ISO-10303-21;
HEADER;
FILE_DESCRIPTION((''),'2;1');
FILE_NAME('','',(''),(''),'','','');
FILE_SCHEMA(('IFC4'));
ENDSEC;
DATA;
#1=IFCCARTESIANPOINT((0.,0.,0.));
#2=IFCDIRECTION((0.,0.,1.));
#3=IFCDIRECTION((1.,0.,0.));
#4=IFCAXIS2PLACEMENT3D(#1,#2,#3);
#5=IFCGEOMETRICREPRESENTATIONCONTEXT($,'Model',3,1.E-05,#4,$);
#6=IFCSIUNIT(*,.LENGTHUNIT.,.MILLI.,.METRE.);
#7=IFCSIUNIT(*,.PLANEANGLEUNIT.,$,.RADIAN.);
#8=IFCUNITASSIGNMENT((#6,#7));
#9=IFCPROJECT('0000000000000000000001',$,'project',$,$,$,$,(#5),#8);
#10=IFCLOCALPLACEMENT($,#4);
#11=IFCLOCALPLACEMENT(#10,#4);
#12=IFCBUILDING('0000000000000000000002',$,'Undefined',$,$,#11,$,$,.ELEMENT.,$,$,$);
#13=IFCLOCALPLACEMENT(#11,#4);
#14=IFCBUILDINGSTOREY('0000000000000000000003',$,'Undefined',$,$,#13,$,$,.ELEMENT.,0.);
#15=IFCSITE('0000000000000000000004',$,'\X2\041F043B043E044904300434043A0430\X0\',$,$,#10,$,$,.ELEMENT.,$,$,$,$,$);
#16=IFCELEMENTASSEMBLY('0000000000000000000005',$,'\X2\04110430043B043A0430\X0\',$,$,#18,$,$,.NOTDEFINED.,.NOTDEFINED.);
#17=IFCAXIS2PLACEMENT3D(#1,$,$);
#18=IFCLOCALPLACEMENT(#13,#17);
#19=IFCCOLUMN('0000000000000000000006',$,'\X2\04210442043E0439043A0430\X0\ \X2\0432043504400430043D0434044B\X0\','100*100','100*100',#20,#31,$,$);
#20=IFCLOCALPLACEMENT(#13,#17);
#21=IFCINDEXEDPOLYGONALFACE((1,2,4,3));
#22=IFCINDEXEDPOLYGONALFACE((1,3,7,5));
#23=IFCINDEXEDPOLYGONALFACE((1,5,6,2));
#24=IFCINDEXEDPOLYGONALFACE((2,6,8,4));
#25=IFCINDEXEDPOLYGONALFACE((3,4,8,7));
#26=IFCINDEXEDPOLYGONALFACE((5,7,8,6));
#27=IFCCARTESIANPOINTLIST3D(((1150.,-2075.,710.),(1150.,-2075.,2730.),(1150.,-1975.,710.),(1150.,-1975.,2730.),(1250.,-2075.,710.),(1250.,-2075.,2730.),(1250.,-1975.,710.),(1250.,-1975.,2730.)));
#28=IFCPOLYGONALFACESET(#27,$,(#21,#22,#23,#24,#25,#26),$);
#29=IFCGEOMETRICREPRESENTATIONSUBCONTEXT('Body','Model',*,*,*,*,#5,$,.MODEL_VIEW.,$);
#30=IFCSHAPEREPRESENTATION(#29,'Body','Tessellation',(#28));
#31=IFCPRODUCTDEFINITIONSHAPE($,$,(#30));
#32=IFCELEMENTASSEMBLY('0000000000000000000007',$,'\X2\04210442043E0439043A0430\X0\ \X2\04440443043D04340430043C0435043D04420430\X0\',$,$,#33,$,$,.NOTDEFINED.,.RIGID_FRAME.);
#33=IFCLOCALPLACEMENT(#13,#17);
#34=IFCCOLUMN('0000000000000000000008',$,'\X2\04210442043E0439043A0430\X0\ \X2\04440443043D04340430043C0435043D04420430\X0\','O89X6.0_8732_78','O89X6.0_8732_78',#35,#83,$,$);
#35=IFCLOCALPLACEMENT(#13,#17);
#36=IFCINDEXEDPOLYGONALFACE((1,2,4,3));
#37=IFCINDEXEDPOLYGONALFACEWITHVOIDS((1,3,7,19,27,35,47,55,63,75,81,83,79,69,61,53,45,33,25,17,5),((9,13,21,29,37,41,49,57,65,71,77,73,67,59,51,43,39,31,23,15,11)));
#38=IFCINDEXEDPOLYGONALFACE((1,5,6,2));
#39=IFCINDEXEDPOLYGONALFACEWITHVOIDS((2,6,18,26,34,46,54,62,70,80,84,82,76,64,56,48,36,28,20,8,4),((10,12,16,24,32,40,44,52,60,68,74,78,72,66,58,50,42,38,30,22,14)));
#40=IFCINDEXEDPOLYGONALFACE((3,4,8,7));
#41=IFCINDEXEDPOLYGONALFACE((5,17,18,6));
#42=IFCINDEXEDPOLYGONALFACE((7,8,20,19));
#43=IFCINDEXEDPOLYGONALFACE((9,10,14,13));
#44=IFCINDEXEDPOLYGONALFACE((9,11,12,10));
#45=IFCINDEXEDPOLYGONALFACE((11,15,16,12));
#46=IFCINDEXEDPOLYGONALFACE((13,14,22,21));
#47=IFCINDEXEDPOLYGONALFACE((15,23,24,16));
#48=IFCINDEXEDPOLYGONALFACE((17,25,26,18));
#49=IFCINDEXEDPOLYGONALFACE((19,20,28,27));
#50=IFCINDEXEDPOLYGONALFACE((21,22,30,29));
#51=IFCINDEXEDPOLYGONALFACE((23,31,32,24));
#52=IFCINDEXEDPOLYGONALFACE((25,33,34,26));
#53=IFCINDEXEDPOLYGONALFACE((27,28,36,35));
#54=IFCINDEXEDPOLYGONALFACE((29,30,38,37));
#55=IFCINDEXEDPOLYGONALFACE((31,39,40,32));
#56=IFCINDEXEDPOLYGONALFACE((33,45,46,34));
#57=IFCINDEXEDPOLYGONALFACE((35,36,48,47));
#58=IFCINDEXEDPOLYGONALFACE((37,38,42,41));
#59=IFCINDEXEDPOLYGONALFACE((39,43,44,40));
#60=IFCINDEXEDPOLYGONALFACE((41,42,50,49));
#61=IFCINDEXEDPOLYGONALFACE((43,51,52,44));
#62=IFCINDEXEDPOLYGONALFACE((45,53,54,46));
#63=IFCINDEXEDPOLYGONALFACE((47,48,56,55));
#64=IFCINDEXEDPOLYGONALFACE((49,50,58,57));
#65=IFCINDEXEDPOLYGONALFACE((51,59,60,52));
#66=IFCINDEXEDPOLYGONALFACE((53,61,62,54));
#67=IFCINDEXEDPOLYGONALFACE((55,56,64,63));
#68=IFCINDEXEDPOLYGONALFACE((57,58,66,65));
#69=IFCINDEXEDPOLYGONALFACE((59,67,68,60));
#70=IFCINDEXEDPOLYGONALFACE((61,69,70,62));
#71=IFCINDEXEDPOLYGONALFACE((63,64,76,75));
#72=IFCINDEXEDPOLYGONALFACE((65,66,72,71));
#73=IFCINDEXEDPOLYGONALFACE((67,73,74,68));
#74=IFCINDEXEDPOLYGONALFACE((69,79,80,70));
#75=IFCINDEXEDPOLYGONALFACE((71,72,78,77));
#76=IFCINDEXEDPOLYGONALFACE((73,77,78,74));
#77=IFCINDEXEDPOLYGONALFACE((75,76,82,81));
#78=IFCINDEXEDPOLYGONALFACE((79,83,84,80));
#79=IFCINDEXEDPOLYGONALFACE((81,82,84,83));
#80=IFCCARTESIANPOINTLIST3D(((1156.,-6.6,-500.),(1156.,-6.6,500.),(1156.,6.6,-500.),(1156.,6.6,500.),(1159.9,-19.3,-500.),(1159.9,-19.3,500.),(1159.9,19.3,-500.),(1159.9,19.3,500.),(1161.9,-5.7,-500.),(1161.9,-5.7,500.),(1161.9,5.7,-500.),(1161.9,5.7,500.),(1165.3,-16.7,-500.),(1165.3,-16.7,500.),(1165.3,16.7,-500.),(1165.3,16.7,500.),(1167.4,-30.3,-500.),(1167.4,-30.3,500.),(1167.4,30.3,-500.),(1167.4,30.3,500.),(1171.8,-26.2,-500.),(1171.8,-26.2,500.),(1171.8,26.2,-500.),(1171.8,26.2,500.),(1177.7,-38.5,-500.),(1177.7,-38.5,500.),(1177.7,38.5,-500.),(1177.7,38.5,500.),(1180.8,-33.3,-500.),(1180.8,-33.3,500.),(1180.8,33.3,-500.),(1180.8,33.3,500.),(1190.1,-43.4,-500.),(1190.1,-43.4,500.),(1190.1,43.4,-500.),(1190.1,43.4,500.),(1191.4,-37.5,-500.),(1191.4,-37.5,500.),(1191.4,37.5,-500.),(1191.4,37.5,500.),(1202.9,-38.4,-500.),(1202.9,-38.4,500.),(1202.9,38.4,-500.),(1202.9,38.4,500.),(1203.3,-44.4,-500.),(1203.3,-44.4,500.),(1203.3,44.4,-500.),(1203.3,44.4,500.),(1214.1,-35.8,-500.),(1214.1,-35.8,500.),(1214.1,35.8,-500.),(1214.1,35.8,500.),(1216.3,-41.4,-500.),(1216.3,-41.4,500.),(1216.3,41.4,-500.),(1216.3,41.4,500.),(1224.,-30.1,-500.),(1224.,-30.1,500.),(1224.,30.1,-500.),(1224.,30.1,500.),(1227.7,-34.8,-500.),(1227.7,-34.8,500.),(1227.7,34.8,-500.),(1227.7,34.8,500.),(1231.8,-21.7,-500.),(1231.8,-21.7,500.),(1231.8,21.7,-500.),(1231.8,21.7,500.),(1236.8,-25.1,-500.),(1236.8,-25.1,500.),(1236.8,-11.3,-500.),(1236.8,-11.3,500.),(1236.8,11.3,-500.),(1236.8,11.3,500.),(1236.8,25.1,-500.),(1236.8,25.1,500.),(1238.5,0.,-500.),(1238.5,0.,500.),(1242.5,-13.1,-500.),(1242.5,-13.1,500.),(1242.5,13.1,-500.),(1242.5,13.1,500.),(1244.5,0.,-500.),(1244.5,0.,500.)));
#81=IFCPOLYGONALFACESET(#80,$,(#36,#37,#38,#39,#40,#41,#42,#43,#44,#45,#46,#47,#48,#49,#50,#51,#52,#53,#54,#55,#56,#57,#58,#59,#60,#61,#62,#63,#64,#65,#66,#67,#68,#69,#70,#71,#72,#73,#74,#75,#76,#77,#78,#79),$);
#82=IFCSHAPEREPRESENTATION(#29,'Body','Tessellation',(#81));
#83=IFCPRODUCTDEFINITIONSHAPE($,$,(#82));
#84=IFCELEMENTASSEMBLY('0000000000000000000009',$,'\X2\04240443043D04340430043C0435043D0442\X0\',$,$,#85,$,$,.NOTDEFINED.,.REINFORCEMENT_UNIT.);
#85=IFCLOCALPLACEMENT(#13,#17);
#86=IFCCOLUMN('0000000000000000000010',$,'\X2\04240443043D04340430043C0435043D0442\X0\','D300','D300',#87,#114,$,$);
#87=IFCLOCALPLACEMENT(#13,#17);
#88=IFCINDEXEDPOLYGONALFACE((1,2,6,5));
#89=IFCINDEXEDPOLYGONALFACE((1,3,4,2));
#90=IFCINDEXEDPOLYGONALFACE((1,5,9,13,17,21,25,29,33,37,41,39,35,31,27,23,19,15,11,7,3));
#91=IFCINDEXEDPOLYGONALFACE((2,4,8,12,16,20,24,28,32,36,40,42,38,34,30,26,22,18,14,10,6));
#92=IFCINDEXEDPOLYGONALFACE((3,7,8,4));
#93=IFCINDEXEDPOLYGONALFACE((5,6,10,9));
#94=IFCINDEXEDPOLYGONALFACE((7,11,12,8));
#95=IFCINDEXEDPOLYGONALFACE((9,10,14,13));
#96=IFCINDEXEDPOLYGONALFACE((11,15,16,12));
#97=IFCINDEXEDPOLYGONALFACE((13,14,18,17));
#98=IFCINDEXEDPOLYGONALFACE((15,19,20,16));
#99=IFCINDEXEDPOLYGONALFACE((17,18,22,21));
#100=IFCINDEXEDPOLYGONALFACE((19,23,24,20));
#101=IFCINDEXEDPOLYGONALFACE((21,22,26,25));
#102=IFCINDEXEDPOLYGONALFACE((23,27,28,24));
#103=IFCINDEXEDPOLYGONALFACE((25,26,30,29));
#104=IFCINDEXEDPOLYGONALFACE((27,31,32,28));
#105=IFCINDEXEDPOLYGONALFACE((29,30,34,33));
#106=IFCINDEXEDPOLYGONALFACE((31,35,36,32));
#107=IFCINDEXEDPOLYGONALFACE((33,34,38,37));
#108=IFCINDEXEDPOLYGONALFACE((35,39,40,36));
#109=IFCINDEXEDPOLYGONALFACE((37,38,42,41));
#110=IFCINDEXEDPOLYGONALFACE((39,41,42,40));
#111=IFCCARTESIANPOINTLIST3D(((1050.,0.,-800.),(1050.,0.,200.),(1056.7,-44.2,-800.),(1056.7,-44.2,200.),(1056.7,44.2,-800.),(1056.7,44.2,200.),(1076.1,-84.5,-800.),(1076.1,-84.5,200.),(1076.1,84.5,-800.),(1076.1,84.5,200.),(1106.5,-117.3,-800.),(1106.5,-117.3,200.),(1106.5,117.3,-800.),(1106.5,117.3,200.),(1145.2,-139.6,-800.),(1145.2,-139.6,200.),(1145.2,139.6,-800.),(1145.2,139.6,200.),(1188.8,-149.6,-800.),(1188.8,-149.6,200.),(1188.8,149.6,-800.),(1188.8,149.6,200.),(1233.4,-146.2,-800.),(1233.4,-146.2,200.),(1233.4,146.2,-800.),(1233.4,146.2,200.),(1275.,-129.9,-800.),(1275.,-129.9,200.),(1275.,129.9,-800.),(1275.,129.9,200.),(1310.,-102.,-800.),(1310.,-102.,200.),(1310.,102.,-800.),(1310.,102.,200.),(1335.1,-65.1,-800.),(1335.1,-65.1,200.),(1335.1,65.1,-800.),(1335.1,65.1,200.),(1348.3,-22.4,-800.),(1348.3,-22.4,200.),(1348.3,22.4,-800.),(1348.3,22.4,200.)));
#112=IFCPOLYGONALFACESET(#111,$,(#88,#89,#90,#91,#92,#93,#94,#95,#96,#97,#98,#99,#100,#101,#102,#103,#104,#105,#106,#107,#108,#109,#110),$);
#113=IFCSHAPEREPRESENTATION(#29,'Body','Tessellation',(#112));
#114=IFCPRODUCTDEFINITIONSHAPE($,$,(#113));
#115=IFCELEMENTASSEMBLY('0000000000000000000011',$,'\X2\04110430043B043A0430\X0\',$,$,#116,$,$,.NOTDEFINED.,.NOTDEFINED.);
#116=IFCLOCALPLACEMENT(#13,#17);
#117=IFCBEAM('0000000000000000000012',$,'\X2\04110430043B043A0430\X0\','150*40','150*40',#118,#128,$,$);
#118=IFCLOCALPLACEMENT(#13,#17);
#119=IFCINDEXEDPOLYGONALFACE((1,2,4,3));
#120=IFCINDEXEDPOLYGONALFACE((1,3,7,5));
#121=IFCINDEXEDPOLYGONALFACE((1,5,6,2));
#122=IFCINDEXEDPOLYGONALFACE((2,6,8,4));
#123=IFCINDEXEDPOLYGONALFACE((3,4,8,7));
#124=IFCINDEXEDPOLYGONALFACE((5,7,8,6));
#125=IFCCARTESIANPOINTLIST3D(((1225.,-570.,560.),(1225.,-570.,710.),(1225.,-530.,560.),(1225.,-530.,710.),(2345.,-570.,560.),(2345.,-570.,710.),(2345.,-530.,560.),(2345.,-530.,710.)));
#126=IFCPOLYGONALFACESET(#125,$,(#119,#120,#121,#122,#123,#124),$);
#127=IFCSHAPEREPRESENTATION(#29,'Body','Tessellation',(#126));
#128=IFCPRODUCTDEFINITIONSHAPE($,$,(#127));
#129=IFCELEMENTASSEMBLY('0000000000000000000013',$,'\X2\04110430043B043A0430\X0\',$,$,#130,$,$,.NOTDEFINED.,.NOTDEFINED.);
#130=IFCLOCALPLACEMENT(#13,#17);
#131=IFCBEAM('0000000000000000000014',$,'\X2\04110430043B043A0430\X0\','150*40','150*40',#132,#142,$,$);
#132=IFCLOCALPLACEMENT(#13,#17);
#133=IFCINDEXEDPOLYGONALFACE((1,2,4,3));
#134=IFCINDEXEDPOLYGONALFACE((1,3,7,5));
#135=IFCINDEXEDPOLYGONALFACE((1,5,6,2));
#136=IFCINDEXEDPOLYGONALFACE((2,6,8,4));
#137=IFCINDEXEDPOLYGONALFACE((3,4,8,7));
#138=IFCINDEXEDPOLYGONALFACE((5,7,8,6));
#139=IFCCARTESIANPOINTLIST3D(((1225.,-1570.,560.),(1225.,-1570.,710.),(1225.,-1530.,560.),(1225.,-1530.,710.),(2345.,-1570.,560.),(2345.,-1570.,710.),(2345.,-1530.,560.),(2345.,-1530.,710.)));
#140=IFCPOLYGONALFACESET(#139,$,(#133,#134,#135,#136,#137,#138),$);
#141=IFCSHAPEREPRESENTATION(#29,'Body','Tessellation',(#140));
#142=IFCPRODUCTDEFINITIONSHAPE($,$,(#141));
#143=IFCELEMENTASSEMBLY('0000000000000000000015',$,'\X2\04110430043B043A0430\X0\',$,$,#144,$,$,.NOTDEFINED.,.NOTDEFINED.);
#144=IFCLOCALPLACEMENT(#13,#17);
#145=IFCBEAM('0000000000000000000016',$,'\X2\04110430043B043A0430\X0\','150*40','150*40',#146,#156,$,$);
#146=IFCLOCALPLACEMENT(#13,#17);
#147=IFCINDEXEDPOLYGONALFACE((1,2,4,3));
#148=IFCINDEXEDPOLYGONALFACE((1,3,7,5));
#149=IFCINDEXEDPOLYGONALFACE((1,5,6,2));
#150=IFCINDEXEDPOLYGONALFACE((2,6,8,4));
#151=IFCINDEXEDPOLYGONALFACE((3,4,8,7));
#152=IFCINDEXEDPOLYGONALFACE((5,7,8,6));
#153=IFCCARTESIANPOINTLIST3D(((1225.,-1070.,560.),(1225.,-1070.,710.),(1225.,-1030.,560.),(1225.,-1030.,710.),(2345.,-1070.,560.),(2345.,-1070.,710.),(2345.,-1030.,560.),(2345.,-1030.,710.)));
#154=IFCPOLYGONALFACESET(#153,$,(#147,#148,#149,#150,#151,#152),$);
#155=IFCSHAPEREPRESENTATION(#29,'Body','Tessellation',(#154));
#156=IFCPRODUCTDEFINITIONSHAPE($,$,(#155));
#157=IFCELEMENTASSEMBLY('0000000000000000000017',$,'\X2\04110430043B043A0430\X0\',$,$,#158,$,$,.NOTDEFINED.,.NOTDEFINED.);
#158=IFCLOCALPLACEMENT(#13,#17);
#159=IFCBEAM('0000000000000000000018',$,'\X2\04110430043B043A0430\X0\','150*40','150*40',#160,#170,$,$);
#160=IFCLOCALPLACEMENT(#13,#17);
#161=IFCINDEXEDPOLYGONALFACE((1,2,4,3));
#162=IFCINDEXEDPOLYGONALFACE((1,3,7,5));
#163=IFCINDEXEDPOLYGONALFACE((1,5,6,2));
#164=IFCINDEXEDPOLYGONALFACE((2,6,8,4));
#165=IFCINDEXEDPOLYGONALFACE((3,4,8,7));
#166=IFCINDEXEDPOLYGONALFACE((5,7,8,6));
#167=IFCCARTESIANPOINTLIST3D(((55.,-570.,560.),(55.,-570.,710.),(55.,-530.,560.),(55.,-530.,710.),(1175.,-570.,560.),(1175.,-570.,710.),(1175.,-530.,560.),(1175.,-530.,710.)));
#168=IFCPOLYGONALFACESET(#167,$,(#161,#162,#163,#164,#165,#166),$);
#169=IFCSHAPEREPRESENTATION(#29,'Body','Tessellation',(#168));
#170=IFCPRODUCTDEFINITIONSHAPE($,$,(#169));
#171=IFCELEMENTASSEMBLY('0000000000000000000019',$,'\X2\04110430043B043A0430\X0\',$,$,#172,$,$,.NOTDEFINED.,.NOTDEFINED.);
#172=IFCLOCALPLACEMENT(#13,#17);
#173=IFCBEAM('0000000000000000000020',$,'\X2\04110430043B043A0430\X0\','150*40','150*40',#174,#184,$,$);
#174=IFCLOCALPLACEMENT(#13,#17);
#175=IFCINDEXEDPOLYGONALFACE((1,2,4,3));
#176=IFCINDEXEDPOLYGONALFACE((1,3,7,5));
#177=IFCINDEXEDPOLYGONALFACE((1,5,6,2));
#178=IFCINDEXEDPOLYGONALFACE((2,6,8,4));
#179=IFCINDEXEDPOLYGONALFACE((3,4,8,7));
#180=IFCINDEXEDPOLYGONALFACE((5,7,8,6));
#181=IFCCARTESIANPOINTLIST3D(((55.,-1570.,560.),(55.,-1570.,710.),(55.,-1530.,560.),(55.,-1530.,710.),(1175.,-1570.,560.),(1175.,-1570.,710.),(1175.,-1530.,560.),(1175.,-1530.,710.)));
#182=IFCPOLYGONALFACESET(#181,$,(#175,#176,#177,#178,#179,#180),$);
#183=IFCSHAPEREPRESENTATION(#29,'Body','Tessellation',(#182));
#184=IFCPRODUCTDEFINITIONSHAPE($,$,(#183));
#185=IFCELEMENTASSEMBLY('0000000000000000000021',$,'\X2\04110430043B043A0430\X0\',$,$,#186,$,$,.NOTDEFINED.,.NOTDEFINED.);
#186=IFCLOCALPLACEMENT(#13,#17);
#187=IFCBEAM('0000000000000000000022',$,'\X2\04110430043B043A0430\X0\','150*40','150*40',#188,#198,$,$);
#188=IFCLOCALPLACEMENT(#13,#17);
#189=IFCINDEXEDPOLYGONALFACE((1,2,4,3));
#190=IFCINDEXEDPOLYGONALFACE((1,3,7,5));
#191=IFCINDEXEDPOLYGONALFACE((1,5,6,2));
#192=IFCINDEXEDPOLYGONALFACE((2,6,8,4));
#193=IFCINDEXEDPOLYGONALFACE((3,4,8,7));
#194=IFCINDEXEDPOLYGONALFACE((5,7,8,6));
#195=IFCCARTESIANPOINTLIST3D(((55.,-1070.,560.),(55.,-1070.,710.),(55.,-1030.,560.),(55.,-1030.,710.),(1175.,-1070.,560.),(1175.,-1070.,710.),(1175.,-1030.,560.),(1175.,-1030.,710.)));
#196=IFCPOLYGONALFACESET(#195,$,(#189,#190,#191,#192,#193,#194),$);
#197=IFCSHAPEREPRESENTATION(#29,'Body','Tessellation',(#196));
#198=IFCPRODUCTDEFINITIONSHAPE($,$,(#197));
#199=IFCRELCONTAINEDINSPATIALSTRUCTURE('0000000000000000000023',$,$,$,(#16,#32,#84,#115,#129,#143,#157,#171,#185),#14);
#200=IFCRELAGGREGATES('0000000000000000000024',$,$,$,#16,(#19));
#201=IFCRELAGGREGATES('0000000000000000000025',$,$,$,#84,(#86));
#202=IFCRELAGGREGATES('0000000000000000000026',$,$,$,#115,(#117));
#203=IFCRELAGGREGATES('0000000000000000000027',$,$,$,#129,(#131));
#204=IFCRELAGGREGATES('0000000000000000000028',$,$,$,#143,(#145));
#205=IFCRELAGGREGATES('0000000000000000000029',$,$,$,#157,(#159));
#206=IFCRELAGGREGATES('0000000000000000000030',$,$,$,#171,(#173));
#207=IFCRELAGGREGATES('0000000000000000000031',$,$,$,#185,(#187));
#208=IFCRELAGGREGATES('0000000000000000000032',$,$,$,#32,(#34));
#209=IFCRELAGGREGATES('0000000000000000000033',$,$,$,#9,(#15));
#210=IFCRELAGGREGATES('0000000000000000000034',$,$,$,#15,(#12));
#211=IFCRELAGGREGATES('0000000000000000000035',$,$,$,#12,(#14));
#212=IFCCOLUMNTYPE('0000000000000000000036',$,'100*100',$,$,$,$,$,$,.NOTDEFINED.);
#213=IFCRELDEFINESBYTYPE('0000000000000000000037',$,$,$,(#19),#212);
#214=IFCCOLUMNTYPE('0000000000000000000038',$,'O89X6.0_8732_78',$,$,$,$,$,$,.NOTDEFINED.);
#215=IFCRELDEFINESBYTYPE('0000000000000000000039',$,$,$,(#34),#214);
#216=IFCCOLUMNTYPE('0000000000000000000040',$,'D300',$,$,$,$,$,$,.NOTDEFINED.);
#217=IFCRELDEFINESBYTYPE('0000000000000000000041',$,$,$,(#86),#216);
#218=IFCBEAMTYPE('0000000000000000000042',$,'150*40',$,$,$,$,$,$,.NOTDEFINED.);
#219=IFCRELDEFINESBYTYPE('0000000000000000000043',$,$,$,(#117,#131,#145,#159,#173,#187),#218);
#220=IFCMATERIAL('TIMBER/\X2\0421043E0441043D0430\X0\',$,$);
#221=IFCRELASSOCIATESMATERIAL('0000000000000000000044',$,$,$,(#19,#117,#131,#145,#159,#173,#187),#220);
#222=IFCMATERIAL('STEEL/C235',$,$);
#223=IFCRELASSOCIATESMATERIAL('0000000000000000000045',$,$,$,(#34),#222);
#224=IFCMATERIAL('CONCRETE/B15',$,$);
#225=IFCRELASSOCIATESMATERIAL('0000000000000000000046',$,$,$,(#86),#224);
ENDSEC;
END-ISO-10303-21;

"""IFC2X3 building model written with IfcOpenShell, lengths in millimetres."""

from ifc_helpers import new_model, si_unit, frame, origin_with_axes, origin_2d_with_axis, place, context, subcontext, project, spatial, rectangle, circle, hollow_circle, extrude, material, type_object, element, aggregate, save


model = new_model("IFC2X3")

# Units and contexts
model_context = context("Model", 3, precision=1e-05, world=origin_with_axes())
body_context = subcontext(model_context, "Body", "Model", "MODEL_VIEW")
ifc_project = project(units=[si_unit("LENGTHUNIT", "METRE", prefix="MILLI"), si_unit("PLANEANGLEUNIT", "RADIAN")], contexts=[model_context])

# Site, building, storey
site_placement = place(None, origin_with_axes())
site = spatial("IfcSite", under=ifc_project, at=site_placement, Name="Площадка", CompositionType="ELEMENT")
building_placement = place(site_placement, origin_with_axes())
building = spatial("IfcBuilding", under=site, at=building_placement, Name="Undefined", CompositionType="ELEMENT")
storey_placement = place(building_placement, origin_with_axes())
storey = spatial("IfcBuildingStorey", under=building, at=storey_placement, Name="Undefined", CompositionType="ELEMENT", Elevation=0.0)

# Element assemblies, columns
assembly_1_placement = place(storey_placement, origin_with_axes())
assembly_1 = element("IfcElementAssembly", 1, at=assembly_1_placement, inside=storey, Name="Балка", AssemblyPlace="NOTDEFINED", PredefinedType="NOTDEFINED")
ifc_material_1 = material(Name="TIMBER/Сосна")
column_type_1 = type_object("IfcColumnType", Name="100*100", PredefinedType="NOTDEFINED")
column_1_placement = place(assembly_1_placement, frame((1200.0, -2025.0, 710.0), z_axis=(0.0, 0.0, 1.0), x_axis=(0.0, 1.0, 0.0)))
column_1 = element("IfcColumn", 2, at=column_1_placement, type_object=column_type_1, material=ifc_material_1, Name="Стойка веранды", Description="100*100", ObjectType="100*100", context=body_context, shape_type="SweptSolid", body=[
    extrude(rectangle(XDim=100.0, YDim=100.0, at=origin_2d_with_axis()), frame((0.0, 0.0, 2020.0), z_axis=(0.0, 0.0, -1.0), x_axis=(0.0, 1.0, 0.0)), (0.0, 0.0, 1.0), 2020.0),
])
aggregate(assembly_1, [column_1])
assembly_2_placement = place(storey_placement, origin_with_axes())
assembly_2 = element("IfcElementAssembly", 3, at=assembly_2_placement, inside=storey, Name="Стойка фундамента", AssemblyPlace="NOTDEFINED", PredefinedType="RIGID_FRAME")
ifc_material_2 = material(Name="STEEL/C235")
column_type_2 = type_object("IfcColumnType", Name="O89X6.0_8732_78", PredefinedType="NOTDEFINED")
column_2_placement = place(assembly_2_placement, frame((1200.0, 0.0, -500.0), z_axis=(0.0, 0.0, 1.0), x_axis=(0.0, -1.0, 0.0)))
column_2 = element("IfcColumn", 4, at=column_2_placement, type_object=column_type_2, material=ifc_material_2, Name="Стойка фундамента", Description="O89X6.0_8732_78", ObjectType="O89X6.0_8732_78", context=body_context, shape_type="SweptSolid", body=[
    extrude(hollow_circle(Radius=44.5, WallThickness=6.0, at=origin_2d_with_axis()), frame((0.0, 0.0, 1000.0), z_axis=(0.0, 0.0, -1.0), x_axis=(0.0, 1.0, 0.0)), (0.0, 0.0, 1.0), 1000.0),
])
assembly_3_placement = place(storey_placement, origin_with_axes())
assembly_3 = element("IfcElementAssembly", 5, at=assembly_3_placement, inside=storey, Name="Фундамент", AssemblyPlace="NOTDEFINED", PredefinedType="REINFORCEMENT_UNIT")
ifc_material_3 = material(Name="CONCRETE/B15")
column_type_3 = type_object("IfcColumnType", Name="D300", PredefinedType="NOTDEFINED")
column_3_placement = place(assembly_3_placement, frame((1200.0, 0.0, -800.0), z_axis=(0.0, 0.0, 1.0), x_axis=(0.0, 1.0, 0.0)))
column_3 = element("IfcColumn", 6, at=column_3_placement, type_object=column_type_3, material=ifc_material_3, Name="Фундамент", Description="D300", ObjectType="D300", context=body_context, shape_type="SweptSolid", body=[
    extrude(circle(Radius=150.0, at=origin_2d_with_axis()), frame((0.0, 0.0, 1000.0), z_axis=(0.0, 0.0, -1.0), x_axis=(0.0, 1.0, 0.0)), (0.0, 0.0, 1.0), 1000.0),
])
aggregate(assembly_3, [column_3])

# Element assemblies, beams
assembly_4_placement = place(storey_placement, origin_with_axes())
assembly_4 = element("IfcElementAssembly", 7, at=assembly_4_placement, inside=storey, Name="Балка", AssemblyPlace="NOTDEFINED", PredefinedType="NOTDEFINED")
beam_type_1 = type_object("IfcBeamType", Name="150*40", PredefinedType="NOTDEFINED")
beam_1_placement = place(assembly_4_placement, frame((2345.0, -550.0, 635.0), z_axis=(0.0, 0.0, -1.0), x_axis=(-1.0, 0.0, 0.0)))
beam_1 = element("IfcBeam", 8, at=beam_1_placement, type_object=beam_type_1, material=ifc_material_1, Name="Балка", Description="150*40", ObjectType="150*40", context=body_context, shape_type="SweptSolid", body=[
    extrude(rectangle(XDim=40.0, YDim=150.0, at=origin_2d_with_axis()), frame((1120.0, 0.0, 0.0), z_axis=(-1.0, 0.0, 0.0), x_axis=(0.0, -1.0, 0.0)), (0.0, 0.0, 1.0), 1120.0),
])
aggregate(assembly_4, [beam_1])
assembly_5_placement = place(storey_placement, origin_with_axes())
assembly_5 = element("IfcElementAssembly", 9, at=assembly_5_placement, inside=storey, Name="Балка", AssemblyPlace="NOTDEFINED", PredefinedType="NOTDEFINED")
beam_2_placement = place(assembly_5_placement, frame((2345.0, -1550.0, 635.0), z_axis=(0.0, 0.0, -1.0), x_axis=(-1.0, 0.0, 0.0)))
beam_2 = element("IfcBeam", 10, at=beam_2_placement, type_object=beam_type_1, material=ifc_material_1, Name="Балка", Description="150*40", ObjectType="150*40", context=body_context, shape_type="SweptSolid", body=[
    extrude(rectangle(XDim=40.0, YDim=150.0, at=origin_2d_with_axis()), frame((1120.0, 0.0, 0.0), z_axis=(-1.0, 0.0, 0.0), x_axis=(0.0, -1.0, 0.0)), (0.0, 0.0, 1.0), 1120.0),
])
aggregate(assembly_5, [beam_2])
assembly_6_placement = place(storey_placement, origin_with_axes())
assembly_6 = element("IfcElementAssembly", 11, at=assembly_6_placement, inside=storey, Name="Балка", AssemblyPlace="NOTDEFINED", PredefinedType="NOTDEFINED")
beam_3_placement = place(assembly_6_placement, frame((2345.0, -1050.0, 635.0), z_axis=(0.0, 0.0, -1.0), x_axis=(-1.0, 0.0, 0.0)))
beam_3 = element("IfcBeam", 12, at=beam_3_placement, type_object=beam_type_1, material=ifc_material_1, Name="Балка", Description="150*40", ObjectType="150*40", context=body_context, shape_type="SweptSolid", body=[
    extrude(rectangle(XDim=40.0, YDim=150.0, at=origin_2d_with_axis()), frame((1120.0, 0.0, 0.0), z_axis=(-1.0, 0.0, 0.0), x_axis=(0.0, -1.0, 0.0)), (0.0, 0.0, 1.0), 1120.0),
])
aggregate(assembly_6, [beam_3])
assembly_7_placement = place(storey_placement, origin_with_axes())
assembly_7 = element("IfcElementAssembly", 13, at=assembly_7_placement, inside=storey, Name="Балка", AssemblyPlace="NOTDEFINED", PredefinedType="NOTDEFINED")
beam_4_placement = place(assembly_7_placement, frame((1175.0, -550.0, 635.0), z_axis=(0.0, 0.0, -1.0), x_axis=(-1.0, 0.0, 0.0)))
beam_4 = element("IfcBeam", 14, at=beam_4_placement, type_object=beam_type_1, material=ifc_material_1, Name="Балка", Description="150*40", ObjectType="150*40", context=body_context, shape_type="SweptSolid", body=[
    extrude(rectangle(XDim=40.0, YDim=150.0, at=origin_2d_with_axis()), frame((1120.0, 0.0, 0.0), z_axis=(-1.0, 0.0, 0.0), x_axis=(0.0, -1.0, 0.0)), (0.0, 0.0, 1.0), 1120.0),
])
aggregate(assembly_7, [beam_4])
assembly_8_placement = place(storey_placement, origin_with_axes())
assembly_8 = element("IfcElementAssembly", 15, at=assembly_8_placement, inside=storey, Name="Балка", AssemblyPlace="NOTDEFINED", PredefinedType="NOTDEFINED")
beam_5_placement = place(assembly_8_placement, frame((1175.0, -1550.0, 635.0), z_axis=(0.0, 0.0, -1.0), x_axis=(-1.0, 0.0, 0.0)))
beam_5 = element("IfcBeam", 16, at=beam_5_placement, type_object=beam_type_1, material=ifc_material_1, Name="Балка", Description="150*40", ObjectType="150*40", context=body_context, shape_type="SweptSolid", body=[
    extrude(rectangle(XDim=40.0, YDim=150.0, at=origin_2d_with_axis()), frame((1120.0, 0.0, 0.0), z_axis=(-1.0, 0.0, 0.0), x_axis=(0.0, -1.0, 0.0)), (0.0, 0.0, 1.0), 1120.0),
])
aggregate(assembly_8, [beam_5])
assembly_9_placement = place(storey_placement, origin_with_axes())
assembly_9 = element("IfcElementAssembly", 17, at=assembly_9_placement, inside=storey, Name="Балка", AssemblyPlace="NOTDEFINED", PredefinedType="NOTDEFINED")
beam_6_placement = place(assembly_9_placement, frame((1175.0, -1050.0, 635.0), z_axis=(0.0, 0.0, -1.0), x_axis=(-1.0, 0.0, 0.0)))
beam_6 = element("IfcBeam", 18, at=beam_6_placement, type_object=beam_type_1, material=ifc_material_1, Name="Балка", Description="150*40", ObjectType="150*40", context=body_context, shape_type="SweptSolid", body=[
    extrude(rectangle(XDim=40.0, YDim=150.0, at=origin_2d_with_axis()), frame((1120.0, 0.0, 0.0), z_axis=(-1.0, 0.0, 0.0), x_axis=(0.0, -1.0, 0.0)), (0.0, 0.0, 1.0), 1120.0),
])
aggregate(assembly_9, [beam_6])

aggregate(assembly_2, [column_2])

save(model, "model.ifc")
